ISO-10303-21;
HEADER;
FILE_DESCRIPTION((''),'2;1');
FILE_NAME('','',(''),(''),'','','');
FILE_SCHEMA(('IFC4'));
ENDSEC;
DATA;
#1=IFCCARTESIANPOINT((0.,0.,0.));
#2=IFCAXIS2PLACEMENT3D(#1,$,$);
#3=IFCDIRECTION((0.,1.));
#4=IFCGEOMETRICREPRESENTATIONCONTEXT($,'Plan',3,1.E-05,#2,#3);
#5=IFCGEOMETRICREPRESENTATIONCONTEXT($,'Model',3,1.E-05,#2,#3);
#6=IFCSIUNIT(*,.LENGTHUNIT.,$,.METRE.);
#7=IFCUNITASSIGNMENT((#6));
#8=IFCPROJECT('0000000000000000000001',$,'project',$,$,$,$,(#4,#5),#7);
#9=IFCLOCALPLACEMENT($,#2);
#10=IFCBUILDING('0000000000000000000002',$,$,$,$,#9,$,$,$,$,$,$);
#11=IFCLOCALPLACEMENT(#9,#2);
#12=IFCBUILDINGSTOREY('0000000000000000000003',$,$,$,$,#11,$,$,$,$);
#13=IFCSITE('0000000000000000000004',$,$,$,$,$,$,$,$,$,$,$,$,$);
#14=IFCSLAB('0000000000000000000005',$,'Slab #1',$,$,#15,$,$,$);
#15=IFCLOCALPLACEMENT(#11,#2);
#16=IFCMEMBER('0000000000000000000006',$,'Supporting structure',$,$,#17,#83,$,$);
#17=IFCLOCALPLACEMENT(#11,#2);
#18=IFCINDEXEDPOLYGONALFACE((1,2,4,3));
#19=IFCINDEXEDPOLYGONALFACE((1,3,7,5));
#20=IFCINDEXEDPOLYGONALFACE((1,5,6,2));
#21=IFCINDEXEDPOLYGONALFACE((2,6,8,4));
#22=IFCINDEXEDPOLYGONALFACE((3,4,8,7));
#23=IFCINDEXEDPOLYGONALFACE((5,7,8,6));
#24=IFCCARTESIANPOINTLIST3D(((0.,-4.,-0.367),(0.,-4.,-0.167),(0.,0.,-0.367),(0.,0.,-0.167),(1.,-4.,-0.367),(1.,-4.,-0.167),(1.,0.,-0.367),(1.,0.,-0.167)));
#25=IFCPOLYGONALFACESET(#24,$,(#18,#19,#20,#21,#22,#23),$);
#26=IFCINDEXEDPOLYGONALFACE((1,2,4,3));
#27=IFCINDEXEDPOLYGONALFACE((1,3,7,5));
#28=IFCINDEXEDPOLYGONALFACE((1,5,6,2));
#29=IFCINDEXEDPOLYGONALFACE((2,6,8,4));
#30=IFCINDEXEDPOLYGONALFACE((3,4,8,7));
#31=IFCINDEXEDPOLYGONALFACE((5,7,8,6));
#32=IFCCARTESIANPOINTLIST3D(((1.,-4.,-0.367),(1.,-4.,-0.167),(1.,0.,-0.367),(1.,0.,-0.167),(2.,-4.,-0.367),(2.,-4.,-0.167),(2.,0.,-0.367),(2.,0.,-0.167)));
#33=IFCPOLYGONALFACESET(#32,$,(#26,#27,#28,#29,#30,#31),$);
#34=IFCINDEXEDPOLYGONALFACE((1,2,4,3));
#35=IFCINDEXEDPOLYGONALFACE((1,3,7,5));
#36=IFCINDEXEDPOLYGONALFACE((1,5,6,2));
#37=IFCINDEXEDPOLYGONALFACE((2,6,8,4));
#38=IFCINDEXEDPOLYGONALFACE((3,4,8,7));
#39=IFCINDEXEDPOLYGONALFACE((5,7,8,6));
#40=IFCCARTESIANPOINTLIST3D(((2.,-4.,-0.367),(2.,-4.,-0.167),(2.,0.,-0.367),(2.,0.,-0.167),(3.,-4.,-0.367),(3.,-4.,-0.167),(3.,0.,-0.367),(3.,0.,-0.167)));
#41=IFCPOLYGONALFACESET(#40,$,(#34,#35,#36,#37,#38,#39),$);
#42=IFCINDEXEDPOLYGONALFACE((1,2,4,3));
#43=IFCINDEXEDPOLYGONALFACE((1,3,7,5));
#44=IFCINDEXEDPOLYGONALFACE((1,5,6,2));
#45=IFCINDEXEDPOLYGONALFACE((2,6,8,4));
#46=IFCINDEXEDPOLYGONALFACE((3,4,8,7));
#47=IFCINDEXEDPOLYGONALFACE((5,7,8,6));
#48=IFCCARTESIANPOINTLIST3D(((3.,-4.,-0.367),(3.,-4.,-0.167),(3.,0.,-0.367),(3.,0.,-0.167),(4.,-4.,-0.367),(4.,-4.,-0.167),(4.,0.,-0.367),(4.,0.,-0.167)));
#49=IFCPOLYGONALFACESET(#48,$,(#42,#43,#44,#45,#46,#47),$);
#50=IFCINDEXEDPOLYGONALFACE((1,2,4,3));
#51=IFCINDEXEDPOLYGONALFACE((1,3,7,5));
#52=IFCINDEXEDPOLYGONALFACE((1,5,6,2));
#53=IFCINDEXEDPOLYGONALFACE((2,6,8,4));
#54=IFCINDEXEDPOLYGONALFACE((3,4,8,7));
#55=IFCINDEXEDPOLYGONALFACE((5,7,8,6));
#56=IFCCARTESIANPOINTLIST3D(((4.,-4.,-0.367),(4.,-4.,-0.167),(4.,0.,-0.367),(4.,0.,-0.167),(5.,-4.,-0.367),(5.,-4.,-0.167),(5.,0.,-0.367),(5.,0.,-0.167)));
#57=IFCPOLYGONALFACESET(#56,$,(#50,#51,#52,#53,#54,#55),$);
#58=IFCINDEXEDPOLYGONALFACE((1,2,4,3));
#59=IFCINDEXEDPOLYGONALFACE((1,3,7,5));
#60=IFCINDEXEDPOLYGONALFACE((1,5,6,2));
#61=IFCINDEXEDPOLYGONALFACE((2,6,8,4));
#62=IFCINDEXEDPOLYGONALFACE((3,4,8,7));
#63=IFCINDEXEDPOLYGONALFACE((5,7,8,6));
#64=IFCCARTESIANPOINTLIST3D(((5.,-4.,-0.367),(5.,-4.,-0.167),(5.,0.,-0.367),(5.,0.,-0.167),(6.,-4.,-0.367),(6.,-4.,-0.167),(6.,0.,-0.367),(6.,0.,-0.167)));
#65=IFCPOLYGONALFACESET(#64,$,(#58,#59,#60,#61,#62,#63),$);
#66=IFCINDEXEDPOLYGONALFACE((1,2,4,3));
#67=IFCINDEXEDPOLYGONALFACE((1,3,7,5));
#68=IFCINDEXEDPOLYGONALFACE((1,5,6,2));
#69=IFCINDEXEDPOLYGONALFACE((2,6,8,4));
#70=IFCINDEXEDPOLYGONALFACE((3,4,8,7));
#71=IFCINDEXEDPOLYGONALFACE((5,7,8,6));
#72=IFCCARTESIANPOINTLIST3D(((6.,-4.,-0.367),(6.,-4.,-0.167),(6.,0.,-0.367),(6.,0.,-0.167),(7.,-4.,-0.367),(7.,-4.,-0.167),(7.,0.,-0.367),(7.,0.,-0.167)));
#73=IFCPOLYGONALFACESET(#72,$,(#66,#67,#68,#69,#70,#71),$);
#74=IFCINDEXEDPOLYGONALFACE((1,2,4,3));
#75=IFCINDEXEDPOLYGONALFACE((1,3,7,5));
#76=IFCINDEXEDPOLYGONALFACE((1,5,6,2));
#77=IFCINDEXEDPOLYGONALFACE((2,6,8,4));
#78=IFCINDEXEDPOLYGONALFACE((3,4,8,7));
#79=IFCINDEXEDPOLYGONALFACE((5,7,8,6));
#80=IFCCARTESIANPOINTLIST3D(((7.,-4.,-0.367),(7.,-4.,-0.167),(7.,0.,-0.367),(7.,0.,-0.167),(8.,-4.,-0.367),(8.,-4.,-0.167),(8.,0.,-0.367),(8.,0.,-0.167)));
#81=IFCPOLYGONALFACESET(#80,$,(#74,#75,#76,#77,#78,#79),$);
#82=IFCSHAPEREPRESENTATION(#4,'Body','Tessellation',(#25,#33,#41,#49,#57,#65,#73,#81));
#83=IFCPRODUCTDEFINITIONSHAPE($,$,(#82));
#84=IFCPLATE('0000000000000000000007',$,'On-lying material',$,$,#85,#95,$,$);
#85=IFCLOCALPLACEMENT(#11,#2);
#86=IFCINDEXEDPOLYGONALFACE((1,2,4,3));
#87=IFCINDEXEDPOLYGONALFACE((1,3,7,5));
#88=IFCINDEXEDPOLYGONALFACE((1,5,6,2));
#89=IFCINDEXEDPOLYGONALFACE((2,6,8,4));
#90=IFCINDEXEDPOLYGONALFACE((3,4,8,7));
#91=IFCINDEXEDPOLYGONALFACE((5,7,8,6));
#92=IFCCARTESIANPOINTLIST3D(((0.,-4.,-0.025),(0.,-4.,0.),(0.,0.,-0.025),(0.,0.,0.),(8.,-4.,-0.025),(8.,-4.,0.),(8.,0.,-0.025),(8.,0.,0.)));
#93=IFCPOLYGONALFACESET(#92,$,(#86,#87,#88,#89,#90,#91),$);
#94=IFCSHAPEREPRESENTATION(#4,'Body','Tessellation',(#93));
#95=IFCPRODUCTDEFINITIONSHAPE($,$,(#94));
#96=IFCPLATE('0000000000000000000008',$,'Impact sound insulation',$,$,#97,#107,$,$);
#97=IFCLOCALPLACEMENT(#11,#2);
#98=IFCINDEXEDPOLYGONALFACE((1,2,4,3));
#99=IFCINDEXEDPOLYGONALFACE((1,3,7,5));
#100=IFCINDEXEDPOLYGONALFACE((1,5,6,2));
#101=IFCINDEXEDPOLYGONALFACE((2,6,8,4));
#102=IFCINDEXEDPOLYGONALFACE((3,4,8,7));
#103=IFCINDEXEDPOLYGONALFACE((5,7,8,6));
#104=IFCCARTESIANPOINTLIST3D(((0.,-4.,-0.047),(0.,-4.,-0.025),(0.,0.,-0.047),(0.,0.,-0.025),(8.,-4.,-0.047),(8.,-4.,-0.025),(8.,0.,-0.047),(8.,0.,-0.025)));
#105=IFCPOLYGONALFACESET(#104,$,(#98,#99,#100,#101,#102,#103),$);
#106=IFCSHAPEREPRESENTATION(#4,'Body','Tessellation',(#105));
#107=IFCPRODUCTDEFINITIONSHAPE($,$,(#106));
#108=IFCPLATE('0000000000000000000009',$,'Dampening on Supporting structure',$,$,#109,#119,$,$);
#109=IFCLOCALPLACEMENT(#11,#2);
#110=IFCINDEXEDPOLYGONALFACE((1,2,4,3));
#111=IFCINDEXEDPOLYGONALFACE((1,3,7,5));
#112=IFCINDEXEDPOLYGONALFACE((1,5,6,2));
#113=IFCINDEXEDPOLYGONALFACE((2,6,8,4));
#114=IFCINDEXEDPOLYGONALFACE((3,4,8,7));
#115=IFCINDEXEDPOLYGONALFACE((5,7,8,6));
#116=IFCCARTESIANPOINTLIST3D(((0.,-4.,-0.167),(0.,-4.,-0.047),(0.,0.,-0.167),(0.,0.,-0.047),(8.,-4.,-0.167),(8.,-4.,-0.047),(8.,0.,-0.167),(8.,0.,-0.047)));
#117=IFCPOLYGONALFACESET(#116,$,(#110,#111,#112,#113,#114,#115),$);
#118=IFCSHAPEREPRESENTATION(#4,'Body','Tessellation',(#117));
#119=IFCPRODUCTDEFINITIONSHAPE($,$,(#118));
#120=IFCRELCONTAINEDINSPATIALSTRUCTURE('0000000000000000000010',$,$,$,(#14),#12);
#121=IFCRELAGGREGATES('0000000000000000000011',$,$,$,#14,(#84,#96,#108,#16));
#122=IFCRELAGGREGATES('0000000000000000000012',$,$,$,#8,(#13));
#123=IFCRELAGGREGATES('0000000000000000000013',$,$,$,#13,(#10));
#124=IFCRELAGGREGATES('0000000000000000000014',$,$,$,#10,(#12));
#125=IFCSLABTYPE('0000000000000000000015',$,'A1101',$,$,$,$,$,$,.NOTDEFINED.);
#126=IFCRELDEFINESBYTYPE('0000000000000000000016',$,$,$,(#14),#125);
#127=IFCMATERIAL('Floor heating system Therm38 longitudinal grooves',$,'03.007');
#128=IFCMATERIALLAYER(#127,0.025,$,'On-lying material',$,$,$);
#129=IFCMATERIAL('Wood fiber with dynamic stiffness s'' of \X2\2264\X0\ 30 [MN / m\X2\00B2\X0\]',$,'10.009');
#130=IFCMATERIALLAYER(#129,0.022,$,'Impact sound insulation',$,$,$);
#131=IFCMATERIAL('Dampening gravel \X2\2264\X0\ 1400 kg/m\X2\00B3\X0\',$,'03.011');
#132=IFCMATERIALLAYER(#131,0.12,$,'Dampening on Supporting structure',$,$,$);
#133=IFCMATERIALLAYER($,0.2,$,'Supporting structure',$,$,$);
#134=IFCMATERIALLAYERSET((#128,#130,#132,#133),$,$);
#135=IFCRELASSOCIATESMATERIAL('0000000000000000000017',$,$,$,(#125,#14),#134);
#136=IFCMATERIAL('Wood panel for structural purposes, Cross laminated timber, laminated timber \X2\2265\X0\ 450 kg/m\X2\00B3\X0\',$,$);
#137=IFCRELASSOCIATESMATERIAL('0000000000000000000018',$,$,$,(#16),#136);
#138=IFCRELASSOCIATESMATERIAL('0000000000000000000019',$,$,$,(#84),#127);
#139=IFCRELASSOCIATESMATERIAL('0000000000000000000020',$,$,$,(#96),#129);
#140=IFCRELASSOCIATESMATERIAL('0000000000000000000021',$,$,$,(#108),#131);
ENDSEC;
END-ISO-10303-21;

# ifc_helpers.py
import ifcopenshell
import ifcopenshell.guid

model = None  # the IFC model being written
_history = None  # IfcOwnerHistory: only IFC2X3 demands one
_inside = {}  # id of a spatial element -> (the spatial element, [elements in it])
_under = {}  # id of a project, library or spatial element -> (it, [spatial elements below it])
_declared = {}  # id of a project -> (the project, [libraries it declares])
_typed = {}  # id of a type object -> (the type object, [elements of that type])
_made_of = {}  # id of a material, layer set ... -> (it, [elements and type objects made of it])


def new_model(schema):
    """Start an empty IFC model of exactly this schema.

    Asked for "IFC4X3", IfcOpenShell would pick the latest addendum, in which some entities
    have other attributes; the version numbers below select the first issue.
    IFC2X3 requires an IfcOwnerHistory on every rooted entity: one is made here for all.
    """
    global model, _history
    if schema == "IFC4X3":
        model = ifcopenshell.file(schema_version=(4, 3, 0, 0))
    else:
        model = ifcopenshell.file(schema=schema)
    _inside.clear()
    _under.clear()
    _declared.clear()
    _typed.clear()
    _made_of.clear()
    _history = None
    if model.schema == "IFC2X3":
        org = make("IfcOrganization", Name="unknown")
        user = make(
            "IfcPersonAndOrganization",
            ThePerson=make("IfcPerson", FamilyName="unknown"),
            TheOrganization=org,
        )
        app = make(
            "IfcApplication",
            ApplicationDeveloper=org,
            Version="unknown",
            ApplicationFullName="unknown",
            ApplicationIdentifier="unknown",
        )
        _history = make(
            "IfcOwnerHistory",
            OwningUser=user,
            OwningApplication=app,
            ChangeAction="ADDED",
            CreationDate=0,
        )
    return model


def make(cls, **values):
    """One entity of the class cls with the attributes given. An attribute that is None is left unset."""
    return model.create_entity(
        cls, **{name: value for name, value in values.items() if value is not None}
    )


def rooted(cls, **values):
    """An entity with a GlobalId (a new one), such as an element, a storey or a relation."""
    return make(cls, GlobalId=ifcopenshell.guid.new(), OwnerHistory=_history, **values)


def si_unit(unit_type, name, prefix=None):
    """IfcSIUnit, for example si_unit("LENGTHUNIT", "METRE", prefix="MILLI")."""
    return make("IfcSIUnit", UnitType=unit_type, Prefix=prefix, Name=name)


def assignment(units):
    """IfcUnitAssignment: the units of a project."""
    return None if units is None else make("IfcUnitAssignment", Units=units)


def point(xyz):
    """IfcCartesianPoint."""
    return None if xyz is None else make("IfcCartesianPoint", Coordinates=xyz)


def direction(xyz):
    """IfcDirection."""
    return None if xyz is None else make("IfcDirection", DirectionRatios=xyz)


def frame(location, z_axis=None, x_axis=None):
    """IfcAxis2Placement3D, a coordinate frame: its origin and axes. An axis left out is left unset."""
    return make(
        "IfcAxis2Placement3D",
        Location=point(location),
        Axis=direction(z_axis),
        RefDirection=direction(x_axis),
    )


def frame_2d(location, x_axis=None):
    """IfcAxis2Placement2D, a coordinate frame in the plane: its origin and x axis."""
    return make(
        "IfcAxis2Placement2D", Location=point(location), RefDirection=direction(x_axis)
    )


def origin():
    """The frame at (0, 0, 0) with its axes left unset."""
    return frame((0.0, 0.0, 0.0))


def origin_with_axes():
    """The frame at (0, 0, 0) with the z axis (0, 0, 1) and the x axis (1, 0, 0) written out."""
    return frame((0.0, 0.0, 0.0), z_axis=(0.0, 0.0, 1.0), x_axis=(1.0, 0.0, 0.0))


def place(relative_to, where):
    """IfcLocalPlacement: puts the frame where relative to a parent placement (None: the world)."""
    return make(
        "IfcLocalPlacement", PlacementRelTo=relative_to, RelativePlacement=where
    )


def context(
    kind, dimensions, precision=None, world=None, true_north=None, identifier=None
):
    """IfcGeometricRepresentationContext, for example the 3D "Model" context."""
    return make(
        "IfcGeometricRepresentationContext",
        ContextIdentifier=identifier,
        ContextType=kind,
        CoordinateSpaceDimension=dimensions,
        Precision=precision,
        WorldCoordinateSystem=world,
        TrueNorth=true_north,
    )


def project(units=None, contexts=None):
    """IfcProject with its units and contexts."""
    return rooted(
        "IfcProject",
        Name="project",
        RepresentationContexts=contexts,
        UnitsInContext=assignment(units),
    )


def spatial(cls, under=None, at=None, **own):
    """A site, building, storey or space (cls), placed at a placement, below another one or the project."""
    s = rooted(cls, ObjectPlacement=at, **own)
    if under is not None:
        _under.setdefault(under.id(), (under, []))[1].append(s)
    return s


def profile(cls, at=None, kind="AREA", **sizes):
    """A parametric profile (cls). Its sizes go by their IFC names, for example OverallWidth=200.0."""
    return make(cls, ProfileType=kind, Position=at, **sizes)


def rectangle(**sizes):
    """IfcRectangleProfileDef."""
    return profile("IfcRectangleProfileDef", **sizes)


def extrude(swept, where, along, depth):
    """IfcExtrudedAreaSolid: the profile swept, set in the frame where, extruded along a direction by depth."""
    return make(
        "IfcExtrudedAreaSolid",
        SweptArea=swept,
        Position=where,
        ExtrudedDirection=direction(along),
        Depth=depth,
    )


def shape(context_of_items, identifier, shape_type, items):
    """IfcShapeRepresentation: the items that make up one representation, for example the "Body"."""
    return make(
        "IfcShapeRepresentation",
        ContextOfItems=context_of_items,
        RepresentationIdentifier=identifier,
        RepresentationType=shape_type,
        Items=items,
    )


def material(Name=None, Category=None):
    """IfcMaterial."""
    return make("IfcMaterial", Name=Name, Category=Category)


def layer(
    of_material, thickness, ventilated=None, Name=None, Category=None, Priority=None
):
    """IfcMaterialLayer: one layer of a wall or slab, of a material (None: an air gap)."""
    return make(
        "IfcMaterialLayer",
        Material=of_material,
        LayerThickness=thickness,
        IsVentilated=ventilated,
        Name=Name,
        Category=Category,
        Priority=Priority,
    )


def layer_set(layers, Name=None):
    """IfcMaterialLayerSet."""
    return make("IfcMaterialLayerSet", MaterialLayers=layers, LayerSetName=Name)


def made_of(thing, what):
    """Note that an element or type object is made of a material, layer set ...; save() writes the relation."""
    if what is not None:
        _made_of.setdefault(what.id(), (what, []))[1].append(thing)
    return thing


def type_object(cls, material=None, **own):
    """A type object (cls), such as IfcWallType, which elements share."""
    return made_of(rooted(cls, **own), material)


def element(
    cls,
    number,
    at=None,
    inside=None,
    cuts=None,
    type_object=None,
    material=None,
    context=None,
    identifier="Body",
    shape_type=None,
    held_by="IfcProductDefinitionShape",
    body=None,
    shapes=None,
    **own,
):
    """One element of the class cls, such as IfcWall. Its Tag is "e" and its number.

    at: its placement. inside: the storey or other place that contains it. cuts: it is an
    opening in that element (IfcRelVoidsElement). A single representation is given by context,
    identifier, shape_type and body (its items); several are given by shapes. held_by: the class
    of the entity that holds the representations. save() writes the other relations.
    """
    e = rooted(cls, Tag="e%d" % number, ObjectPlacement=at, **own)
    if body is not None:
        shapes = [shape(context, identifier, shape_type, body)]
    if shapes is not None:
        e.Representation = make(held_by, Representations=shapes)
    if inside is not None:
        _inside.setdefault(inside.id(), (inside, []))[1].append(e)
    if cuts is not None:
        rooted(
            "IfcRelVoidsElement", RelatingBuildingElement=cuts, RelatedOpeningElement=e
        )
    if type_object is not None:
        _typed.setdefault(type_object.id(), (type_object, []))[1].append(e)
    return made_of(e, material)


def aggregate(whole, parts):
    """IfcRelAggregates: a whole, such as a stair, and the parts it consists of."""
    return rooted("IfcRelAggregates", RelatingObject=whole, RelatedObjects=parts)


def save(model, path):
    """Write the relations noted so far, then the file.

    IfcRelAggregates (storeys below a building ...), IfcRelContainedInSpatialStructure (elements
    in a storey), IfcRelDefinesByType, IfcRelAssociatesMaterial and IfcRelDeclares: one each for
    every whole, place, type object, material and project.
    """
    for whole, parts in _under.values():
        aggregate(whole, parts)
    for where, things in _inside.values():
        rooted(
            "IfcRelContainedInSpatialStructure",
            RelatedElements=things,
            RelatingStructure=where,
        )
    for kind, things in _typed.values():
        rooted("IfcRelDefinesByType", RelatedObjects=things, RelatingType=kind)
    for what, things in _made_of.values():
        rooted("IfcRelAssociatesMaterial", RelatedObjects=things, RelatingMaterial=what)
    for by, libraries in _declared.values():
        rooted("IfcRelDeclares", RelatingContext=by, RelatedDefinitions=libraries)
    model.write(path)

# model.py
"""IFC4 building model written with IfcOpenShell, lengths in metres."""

from ifc_helpers import new_model, si_unit, direction, frame, frame_2d, origin, origin_with_axes, place, context, project, spatial, rectangle, extrude, material, layer, layer_set, type_object, element, aggregate, save


model = new_model("IFC4")

# Units and contexts
plan_context = context("Plan", 3, precision=1e-05, world=origin(), true_north=direction((0.0, 1.0)))
model_context = context("Model", 3, precision=1e-05, world=origin(), true_north=direction((0.0, 1.0)))
ifc_project = project(units=[si_unit("LENGTHUNIT", "METRE")], contexts=[plan_context, model_context])

# Site, building, storey
site = spatial("IfcSite", under=ifc_project)
building_placement = place(None, origin())
building = spatial("IfcBuilding", under=site, at=building_placement)
storey_placement = place(building_placement, origin())
storey = spatial("IfcBuildingStorey", under=building, at=storey_placement)

# Slab, member, plates
ifc_material_1 = material(Name="Floor heating system Therm38 longitudinal grooves", Category="03.007")
ifc_layer_1 = layer(ifc_material_1, 0.025, Name="On-lying material")
ifc_material_2 = material(Name="Wood fiber with dynamic stiffness s' of ≤ 30 [MN / m²]", Category="10.009")
ifc_layer_2 = layer(ifc_material_2, 0.022, Name="Impact sound insulation")
ifc_material_3 = material(Name="Dampening gravel ≤ 1400 kg/m³", Category="03.011")
ifc_layer_3 = layer(ifc_material_3, 0.12, Name="Dampening on Supporting structure")
ifc_layer_4 = layer(None, 0.2, Name="Supporting structure")
ifc_layer_set = layer_set([ifc_layer_1, ifc_layer_2, ifc_layer_3, ifc_layer_4])
slab_type = type_object("IfcSlabType", Name="A1101", PredefinedType="NOTDEFINED", material=ifc_layer_set)
slab_placement = place(None, frame((0.0, 0.0, 0.0), z_axis=(0.0, 0.0, -1.0), x_axis=(1.0, 0.0, 0.0)))
slab = element("IfcSlab", 1, at=slab_placement, inside=storey, type_object=slab_type, material=ifc_layer_set, Name="Slab #1")
ifc_material_4 = material(Name="Wood panel for structural purposes, Cross laminated timber, laminated timber ≥ 450 kg/m³")
member_placement = place(slab_placement, origin())
member = element("IfcMember", 2, at=member_placement, material=ifc_material_4, Name="Supporting structure", context=plan_context, shape_type="SweptSolid", body=[
    extrude(rectangle(XDim=1.0, YDim=0.2, at=frame_2d((0.5, 0.1), x_axis=(1.0, 0.0))), frame((0.0, 4.0, 0.167), z_axis=(0.0, -1.0, 0.0), x_axis=(1.0, 0.0, 0.0)), (0.0, 0.0, 1.0), 4.0),
    extrude(rectangle(XDim=1.0, YDim=0.2, at=frame_2d((0.5, 0.1), x_axis=(1.0, 0.0))), frame((1.0, 4.0, 0.167), z_axis=(0.0, -1.0, 0.0), x_axis=(1.0, 0.0, 0.0)), (0.0, 0.0, 1.0), 4.0),
    extrude(rectangle(XDim=1.0, YDim=0.2, at=frame_2d((0.5, 0.1), x_axis=(1.0, 0.0))), frame((2.0, 4.0, 0.167), z_axis=(0.0, -1.0, 0.0), x_axis=(1.0, 0.0, 0.0)), (0.0, 0.0, 1.0), 4.0),
    extrude(rectangle(XDim=1.0, YDim=0.2, at=frame_2d((0.5, 0.1), x_axis=(1.0, 0.0))), frame((3.0, 4.0, 0.167), z_axis=(0.0, -1.0, 0.0), x_axis=(1.0, 0.0, 0.0)), (0.0, 0.0, 1.0), 4.0),
    extrude(rectangle(XDim=1.0, YDim=0.2, at=frame_2d((0.5, 0.1), x_axis=(1.0, 0.0))), frame((4.0, 4.0, 0.167), z_axis=(0.0, -1.0, 0.0), x_axis=(1.0, 0.0, 0.0)), (0.0, 0.0, 1.0), 4.0),
    extrude(rectangle(XDim=1.0, YDim=0.2, at=frame_2d((0.5, 0.1), x_axis=(1.0, 0.0))), frame((5.0, 4.0, 0.167), z_axis=(0.0, -1.0, 0.0), x_axis=(1.0, 0.0, 0.0)), (0.0, 0.0, 1.0), 4.0),
    extrude(rectangle(XDim=1.0, YDim=0.2, at=frame_2d((0.5, 0.1), x_axis=(1.0, 0.0))), frame((6.0, 4.0, 0.167), z_axis=(0.0, -1.0, 0.0), x_axis=(1.0, 0.0, 0.0)), (0.0, 0.0, 1.0), 4.0),
    extrude(rectangle(XDim=1.0, YDim=0.2, at=frame_2d((0.5, 0.1), x_axis=(1.0, 0.0))), frame((7.0, 4.0, 0.167), z_axis=(0.0, -1.0, 0.0), x_axis=(1.0, 0.0, 0.0)), (0.0, 0.0, 1.0), 4.0),
])
plate_1_placement = place(slab_placement, origin())
plate_1 = element("IfcPlate", 3, at=plate_1_placement, material=ifc_material_1, Name="On-lying material", context=plan_context, shape_type="SweptSolid", body=[
    extrude(rectangle(XDim=8.0, YDim=4.0, at=frame_2d((4.0, 2.0), x_axis=(1.0, 0.0))), origin_with_axes(), (0.0, 0.0, 1.0), 0.025),
])
plate_2_placement = place(slab_placement, origin())
plate_2 = element("IfcPlate", 4, at=plate_2_placement, material=ifc_material_2, Name="Impact sound insulation", context=plan_context, shape_type="SweptSolid", body=[
    extrude(rectangle(XDim=8.0, YDim=4.0, at=frame_2d((4.0, 2.0), x_axis=(1.0, 0.0))), frame((0.0, 0.0, 0.025), z_axis=(0.0, 0.0, 1.0), x_axis=(1.0, 0.0, 0.0)), (0.0, 0.0, 1.0), 0.022),
])
plate_3_placement = place(slab_placement, origin())
plate_3 = element("IfcPlate", 5, at=plate_3_placement, material=ifc_material_3, Name="Dampening on Supporting structure", context=plan_context, shape_type="SweptSolid", body=[
    extrude(rectangle(XDim=8.0, YDim=4.0, at=frame_2d((4.0, 2.0), x_axis=(1.0, 0.0))), frame((0.0, 0.0, 0.047), z_axis=(0.0, 0.0, 1.0), x_axis=(1.0, 0.0, 0.0)), (0.0, 0.0, 1.0), 0.12),
])
aggregate(slab, [plate_1, plate_2, plate_3, member])

save(model, "model.ifc")
